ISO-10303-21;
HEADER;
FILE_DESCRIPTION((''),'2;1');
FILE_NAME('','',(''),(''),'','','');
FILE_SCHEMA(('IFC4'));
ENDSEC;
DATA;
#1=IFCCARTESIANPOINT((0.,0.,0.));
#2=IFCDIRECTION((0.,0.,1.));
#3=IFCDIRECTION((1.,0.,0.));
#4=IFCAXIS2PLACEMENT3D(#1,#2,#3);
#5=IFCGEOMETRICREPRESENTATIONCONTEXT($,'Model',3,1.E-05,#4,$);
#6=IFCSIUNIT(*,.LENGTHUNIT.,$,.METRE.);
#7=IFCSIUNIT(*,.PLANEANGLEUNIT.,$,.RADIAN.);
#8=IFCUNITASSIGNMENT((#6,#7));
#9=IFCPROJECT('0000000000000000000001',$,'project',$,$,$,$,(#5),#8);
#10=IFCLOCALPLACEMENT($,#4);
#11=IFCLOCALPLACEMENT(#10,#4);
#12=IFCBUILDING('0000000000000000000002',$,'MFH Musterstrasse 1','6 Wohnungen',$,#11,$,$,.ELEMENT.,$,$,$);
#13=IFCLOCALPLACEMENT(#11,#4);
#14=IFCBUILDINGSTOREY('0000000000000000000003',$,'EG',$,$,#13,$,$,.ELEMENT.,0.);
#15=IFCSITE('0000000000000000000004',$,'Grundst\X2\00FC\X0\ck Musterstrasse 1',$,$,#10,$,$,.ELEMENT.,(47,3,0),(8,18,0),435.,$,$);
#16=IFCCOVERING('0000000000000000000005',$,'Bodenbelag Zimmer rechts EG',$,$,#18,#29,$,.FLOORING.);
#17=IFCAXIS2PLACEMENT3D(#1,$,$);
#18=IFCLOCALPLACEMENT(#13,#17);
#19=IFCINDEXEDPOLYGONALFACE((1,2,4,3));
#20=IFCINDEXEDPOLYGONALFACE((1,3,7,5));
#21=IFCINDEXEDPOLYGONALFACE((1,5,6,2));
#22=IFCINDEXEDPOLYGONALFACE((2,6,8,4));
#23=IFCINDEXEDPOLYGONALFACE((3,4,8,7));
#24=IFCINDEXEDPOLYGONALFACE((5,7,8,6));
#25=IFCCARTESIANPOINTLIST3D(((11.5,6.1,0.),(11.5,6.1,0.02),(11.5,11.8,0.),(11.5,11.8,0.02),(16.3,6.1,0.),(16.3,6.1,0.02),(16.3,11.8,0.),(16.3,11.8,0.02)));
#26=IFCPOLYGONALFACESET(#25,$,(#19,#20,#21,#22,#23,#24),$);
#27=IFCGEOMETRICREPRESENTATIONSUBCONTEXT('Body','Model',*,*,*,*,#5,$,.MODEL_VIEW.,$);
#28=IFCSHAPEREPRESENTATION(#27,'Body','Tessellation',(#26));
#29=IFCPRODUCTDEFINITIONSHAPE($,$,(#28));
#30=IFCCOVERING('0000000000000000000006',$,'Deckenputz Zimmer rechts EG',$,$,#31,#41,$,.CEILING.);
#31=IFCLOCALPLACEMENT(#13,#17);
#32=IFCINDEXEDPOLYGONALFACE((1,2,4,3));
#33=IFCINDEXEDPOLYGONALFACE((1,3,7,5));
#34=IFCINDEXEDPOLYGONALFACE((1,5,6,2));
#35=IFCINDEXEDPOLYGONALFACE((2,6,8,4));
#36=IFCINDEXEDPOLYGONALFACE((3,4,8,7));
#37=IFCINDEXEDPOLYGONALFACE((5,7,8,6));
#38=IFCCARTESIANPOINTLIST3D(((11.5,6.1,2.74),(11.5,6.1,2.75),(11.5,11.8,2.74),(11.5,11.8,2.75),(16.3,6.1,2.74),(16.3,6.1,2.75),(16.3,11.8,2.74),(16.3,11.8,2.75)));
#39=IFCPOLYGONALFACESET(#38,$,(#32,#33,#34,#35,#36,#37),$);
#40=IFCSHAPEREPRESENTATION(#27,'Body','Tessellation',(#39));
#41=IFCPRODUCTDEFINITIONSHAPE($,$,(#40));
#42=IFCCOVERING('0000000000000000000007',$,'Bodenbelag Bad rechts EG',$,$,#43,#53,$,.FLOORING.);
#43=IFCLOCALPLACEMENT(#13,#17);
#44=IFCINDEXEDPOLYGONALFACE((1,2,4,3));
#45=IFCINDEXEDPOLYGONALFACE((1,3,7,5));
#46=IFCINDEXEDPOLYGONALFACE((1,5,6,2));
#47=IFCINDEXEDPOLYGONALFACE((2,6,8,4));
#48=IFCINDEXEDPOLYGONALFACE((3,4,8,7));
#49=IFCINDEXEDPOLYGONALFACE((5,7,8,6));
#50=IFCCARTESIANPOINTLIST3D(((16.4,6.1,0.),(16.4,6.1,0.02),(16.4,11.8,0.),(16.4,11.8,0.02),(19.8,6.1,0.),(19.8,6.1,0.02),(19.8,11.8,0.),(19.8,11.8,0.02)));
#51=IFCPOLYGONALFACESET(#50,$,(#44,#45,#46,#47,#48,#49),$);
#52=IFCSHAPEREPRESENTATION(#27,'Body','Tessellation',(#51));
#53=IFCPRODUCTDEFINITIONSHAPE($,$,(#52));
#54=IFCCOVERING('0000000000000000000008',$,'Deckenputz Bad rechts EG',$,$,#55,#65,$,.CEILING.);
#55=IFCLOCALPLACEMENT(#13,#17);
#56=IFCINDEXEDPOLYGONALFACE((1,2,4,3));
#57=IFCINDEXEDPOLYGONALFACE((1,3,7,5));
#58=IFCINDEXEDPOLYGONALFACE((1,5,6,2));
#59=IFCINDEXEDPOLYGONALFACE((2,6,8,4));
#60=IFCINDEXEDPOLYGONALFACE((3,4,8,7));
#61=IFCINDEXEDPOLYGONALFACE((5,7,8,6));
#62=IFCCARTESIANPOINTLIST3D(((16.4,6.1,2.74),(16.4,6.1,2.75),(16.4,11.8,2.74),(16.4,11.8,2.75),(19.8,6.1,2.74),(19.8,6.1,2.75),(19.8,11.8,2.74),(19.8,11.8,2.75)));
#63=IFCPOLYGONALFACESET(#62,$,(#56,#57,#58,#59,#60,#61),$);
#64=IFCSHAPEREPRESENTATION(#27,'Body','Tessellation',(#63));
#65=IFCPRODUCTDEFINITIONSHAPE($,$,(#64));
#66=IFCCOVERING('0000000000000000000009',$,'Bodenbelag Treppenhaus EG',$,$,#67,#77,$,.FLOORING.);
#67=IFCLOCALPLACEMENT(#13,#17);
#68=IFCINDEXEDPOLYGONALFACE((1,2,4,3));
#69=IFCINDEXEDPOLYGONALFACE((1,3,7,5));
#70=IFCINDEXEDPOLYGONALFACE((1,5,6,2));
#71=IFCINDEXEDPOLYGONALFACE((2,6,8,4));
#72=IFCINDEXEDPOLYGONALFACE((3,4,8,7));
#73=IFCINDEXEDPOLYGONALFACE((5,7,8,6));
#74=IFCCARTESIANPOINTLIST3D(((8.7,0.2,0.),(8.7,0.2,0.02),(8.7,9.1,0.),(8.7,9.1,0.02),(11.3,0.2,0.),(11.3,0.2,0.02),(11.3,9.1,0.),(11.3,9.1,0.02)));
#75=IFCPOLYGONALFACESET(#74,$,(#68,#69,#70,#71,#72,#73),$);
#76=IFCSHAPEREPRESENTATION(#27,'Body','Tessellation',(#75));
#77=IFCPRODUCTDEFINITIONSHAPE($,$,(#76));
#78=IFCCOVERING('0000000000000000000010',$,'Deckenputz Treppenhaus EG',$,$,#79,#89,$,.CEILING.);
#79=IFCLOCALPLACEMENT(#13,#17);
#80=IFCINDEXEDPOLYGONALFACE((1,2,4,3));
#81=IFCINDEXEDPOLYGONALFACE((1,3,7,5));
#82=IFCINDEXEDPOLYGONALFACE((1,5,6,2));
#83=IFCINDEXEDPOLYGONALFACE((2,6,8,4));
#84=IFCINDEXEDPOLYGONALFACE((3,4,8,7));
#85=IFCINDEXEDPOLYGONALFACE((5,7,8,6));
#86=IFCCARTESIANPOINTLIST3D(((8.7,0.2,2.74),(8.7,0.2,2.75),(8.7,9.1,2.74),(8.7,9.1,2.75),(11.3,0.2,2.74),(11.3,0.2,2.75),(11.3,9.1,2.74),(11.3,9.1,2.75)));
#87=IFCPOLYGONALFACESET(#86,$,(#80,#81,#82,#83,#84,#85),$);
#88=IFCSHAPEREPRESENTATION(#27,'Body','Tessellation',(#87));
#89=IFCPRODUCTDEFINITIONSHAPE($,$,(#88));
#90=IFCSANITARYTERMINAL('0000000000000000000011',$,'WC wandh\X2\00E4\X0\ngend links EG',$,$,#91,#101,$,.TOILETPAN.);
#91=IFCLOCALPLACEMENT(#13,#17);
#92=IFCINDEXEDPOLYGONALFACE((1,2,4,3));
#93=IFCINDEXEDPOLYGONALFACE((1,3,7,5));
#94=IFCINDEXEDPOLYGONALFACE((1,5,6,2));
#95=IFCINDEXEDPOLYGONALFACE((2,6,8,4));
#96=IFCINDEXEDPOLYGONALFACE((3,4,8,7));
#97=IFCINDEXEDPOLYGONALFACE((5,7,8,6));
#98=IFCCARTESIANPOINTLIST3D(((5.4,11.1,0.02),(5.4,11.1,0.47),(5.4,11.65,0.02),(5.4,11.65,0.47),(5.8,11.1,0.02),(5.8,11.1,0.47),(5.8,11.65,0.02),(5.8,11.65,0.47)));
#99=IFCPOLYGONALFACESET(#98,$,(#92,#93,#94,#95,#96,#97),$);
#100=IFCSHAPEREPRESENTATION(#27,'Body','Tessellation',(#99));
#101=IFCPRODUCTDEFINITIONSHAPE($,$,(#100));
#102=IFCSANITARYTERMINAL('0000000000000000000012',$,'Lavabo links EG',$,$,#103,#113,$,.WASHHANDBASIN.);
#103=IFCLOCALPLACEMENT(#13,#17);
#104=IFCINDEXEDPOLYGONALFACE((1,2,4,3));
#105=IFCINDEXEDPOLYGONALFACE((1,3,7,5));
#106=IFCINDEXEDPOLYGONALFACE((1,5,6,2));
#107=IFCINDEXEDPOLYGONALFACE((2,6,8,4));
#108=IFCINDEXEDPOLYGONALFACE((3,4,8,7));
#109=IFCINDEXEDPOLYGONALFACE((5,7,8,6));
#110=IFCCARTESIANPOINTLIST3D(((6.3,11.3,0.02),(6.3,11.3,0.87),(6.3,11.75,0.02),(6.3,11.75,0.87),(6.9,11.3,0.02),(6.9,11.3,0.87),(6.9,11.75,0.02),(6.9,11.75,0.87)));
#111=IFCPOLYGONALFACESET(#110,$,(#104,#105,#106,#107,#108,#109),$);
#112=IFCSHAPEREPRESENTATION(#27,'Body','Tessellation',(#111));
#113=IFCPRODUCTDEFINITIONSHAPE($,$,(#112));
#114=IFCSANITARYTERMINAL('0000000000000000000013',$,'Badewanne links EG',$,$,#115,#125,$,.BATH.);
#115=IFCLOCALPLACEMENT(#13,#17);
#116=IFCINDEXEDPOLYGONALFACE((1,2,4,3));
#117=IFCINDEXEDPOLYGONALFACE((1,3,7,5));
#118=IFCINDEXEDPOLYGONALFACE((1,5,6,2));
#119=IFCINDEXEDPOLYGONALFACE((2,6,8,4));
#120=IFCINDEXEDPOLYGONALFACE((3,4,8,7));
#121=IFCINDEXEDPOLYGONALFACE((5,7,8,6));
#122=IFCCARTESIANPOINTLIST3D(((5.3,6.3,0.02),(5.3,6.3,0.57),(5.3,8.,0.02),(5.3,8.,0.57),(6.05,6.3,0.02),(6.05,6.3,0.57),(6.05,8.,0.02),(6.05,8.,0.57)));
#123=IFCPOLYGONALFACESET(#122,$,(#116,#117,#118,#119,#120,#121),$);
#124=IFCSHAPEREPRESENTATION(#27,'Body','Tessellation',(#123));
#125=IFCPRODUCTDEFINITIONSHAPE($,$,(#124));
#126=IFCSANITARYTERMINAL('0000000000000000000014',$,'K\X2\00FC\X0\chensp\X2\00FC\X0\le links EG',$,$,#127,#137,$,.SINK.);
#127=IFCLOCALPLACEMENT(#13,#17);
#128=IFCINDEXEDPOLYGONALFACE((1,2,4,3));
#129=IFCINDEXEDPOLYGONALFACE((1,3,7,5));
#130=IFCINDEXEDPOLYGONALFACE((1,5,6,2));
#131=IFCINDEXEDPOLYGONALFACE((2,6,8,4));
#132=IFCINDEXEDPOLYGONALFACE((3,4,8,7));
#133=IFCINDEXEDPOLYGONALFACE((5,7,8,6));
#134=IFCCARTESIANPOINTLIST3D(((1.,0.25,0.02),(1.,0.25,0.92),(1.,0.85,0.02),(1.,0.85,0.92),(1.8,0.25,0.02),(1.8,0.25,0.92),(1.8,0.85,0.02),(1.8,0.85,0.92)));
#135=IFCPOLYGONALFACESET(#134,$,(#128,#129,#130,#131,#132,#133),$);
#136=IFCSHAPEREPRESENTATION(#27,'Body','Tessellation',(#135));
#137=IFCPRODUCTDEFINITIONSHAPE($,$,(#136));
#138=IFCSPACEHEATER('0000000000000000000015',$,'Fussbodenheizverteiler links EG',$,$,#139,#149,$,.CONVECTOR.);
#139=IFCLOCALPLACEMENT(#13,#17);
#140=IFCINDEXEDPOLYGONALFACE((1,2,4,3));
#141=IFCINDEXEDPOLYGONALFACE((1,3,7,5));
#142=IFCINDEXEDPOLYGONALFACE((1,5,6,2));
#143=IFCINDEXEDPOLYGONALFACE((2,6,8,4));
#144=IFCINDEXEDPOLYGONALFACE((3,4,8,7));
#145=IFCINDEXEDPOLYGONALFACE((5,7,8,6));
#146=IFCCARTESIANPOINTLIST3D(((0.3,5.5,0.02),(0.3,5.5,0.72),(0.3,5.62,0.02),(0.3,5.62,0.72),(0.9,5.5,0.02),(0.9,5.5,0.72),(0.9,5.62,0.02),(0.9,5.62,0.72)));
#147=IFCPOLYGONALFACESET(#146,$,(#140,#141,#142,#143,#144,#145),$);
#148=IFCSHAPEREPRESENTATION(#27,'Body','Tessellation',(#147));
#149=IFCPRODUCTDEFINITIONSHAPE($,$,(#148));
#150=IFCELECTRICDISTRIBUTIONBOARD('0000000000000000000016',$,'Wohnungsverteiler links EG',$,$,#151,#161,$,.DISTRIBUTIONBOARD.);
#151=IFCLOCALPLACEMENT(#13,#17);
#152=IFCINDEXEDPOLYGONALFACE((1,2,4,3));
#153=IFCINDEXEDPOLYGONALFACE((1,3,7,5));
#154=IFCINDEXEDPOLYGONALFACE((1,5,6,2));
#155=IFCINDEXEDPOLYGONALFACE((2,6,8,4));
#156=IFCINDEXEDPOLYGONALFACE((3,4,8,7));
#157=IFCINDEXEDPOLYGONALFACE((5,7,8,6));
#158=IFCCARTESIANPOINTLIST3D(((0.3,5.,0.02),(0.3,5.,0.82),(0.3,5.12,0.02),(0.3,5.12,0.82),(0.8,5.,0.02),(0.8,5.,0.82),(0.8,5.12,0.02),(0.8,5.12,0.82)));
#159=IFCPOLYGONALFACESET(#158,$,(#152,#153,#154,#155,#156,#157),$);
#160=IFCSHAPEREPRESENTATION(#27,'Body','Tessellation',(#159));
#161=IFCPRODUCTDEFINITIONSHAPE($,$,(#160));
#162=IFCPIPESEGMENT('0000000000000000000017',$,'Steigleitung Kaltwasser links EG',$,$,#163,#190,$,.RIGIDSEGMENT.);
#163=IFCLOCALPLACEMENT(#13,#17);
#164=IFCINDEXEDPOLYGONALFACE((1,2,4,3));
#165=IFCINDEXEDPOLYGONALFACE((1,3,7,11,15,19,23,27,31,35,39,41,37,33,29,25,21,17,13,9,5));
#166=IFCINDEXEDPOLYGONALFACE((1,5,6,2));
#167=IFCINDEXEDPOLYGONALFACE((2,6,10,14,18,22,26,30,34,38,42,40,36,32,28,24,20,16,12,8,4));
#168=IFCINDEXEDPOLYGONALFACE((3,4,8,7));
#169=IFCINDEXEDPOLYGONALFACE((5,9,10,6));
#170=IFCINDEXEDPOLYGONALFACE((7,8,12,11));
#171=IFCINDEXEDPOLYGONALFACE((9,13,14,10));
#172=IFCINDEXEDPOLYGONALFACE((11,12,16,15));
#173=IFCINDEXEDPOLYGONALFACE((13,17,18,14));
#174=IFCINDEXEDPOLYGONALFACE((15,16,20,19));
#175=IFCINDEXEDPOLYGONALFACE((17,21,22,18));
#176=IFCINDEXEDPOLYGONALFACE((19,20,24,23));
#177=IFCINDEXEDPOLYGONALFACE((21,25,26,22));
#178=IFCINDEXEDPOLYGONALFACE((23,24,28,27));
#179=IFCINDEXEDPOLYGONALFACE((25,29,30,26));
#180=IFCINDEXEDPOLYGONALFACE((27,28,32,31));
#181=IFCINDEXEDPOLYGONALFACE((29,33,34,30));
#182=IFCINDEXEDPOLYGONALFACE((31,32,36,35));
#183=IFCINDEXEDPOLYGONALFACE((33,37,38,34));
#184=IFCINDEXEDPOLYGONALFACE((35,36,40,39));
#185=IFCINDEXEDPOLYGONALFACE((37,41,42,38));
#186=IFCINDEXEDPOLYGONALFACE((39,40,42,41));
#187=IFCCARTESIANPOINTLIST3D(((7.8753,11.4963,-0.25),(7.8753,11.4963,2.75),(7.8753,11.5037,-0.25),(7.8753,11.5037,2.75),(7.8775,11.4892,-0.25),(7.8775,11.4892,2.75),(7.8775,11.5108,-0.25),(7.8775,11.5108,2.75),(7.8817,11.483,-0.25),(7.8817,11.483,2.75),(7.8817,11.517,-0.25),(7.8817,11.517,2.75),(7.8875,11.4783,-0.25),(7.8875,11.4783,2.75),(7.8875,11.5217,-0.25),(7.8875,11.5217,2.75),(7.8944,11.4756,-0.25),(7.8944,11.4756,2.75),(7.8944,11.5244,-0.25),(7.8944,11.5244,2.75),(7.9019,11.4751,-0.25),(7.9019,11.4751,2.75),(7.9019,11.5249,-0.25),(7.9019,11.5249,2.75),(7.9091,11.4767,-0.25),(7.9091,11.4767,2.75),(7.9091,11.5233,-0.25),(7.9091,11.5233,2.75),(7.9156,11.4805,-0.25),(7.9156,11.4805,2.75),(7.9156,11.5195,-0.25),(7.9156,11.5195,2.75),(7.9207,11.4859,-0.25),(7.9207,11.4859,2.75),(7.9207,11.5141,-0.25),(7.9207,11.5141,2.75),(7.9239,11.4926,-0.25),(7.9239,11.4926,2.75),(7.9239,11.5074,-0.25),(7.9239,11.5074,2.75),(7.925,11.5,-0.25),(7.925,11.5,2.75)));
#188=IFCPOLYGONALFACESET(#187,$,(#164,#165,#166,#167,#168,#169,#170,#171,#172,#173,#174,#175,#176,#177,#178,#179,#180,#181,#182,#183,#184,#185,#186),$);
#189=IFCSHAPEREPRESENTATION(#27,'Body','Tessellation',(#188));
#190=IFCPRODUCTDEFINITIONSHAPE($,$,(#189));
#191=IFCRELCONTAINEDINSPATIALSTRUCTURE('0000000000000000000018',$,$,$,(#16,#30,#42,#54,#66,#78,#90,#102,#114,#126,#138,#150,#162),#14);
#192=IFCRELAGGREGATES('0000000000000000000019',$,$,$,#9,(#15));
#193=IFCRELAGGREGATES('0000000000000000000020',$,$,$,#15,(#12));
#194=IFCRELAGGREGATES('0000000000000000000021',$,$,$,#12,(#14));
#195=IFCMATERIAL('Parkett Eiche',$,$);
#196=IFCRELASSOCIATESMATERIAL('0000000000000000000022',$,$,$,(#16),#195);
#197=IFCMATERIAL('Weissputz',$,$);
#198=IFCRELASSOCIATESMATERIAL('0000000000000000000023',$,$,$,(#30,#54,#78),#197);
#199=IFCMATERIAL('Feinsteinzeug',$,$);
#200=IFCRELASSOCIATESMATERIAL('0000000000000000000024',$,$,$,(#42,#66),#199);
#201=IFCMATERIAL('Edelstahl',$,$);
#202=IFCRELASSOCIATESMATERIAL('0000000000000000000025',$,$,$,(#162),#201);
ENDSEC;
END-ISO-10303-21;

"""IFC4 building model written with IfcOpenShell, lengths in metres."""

from ifc_helpers import new_model, si_unit, frame, frame_2d, origin_with_axes, origin_2d_with_axis, place, context, subcontext, project, spatial, rectangle, circle, extrude, material, element, save


model = new_model("IFC4")

# Units and contexts
model_context = context("Model", 3, precision=1e-05, world=origin_with_axes())
body_context = subcontext(model_context, "Body", "Model", "MODEL_VIEW")
ifc_project = project(units=[si_unit("LENGTHUNIT", "METRE"), si_unit("PLANEANGLEUNIT", "RADIAN")], contexts=[model_context])

# Site, building, storey
site_placement = place(None, origin_with_axes())
site = spatial("IfcSite", under=ifc_project, at=site_placement, Name="Grundstück Musterstrasse 1", CompositionType="ELEMENT", RefLatitude=(47, 3, 0), RefLongitude=(8, 18, 0), RefElevation=435.0)
building_placement = place(site_placement, origin_with_axes())
building = spatial("IfcBuilding", under=site, at=building_placement, Name="MFH Musterstrasse 1", Description="6 Wohnungen", CompositionType="ELEMENT")
storey_placement = place(building_placement, origin_with_axes())
storey = spatial("IfcBuildingStorey", under=building, at=storey_placement, Name="EG", CompositionType="ELEMENT", Elevation=0.0)

# Coverings
ifc_material_1 = material(Name="Parkett Eiche")
covering_1_placement = place(storey_placement, origin_with_axes())
element("IfcCovering", 1, at=covering_1_placement, inside=storey, material=ifc_material_1, Name="Bodenbelag Zimmer rechts EG", PredefinedType="FLOORING", context=body_context, shape_type="SweptSolid", body=[
    extrude(rectangle(XDim=4.8, YDim=5.7, at=frame_2d((2.4, 2.85), x_axis=(1.0, 0.0))), frame((11.5, 6.1, 0.0), z_axis=(0.0, 0.0, 1.0), x_axis=(1.0, 0.0, 0.0)), (0.0, 0.0, 1.0), 0.02),
])
ifc_material_2 = material(Name="Weissputz")
covering_2_placement = place(storey_placement, origin_with_axes())
element("IfcCovering", 2, at=covering_2_placement, inside=storey, material=ifc_material_2, Name="Deckenputz Zimmer rechts EG", PredefinedType="CEILING", context=body_context, shape_type="SweptSolid", body=[
    extrude(rectangle(XDim=4.8, YDim=5.7, at=frame_2d((2.4, 2.85), x_axis=(1.0, 0.0))), frame((11.5, 6.1, 2.74), z_axis=(0.0, 0.0, 1.0), x_axis=(1.0, 0.0, 0.0)), (0.0, 0.0, 1.0), 0.01),
])
ifc_material_3 = material(Name="Feinsteinzeug")
covering_3_placement = place(storey_placement, origin_with_axes())
element("IfcCovering", 3, at=covering_3_placement, inside=storey, material=ifc_material_3, Name="Bodenbelag Bad rechts EG", PredefinedType="FLOORING", context=body_context, shape_type="SweptSolid", body=[
    extrude(rectangle(XDim=3.4, YDim=5.7, at=frame_2d((1.7, 2.85), x_axis=(1.0, 0.0))), frame((16.4, 6.1, 0.0), z_axis=(0.0, 0.0, 1.0), x_axis=(1.0, 0.0, 0.0)), (0.0, 0.0, 1.0), 0.02),
])
covering_4_placement = place(storey_placement, origin_with_axes())
element("IfcCovering", 4, at=covering_4_placement, inside=storey, material=ifc_material_2, Name="Deckenputz Bad rechts EG", PredefinedType="CEILING", context=body_context, shape_type="SweptSolid", body=[
    extrude(rectangle(XDim=3.4, YDim=5.7, at=frame_2d((1.7, 2.85), x_axis=(1.0, 0.0))), frame((16.4, 6.1, 2.74), z_axis=(0.0, 0.0, 1.0), x_axis=(1.0, 0.0, 0.0)), (0.0, 0.0, 1.0), 0.01),
])
covering_5_placement = place(storey_placement, origin_with_axes())
element("IfcCovering", 5, at=covering_5_placement, inside=storey, material=ifc_material_3, Name="Bodenbelag Treppenhaus EG", PredefinedType="FLOORING", context=body_context, shape_type="SweptSolid", body=[
    extrude(rectangle(XDim=2.6, YDim=8.9, at=frame_2d((1.3, 4.45), x_axis=(1.0, 0.0))), frame((8.7, 0.2, 0.0), z_axis=(0.0, 0.0, 1.0), x_axis=(1.0, 0.0, 0.0)), (0.0, 0.0, 1.0), 0.02),
])
covering_6_placement = place(storey_placement, origin_with_axes())
element("IfcCovering", 6, at=covering_6_placement, inside=storey, material=ifc_material_2, Name="Deckenputz Treppenhaus EG", PredefinedType="CEILING", context=body_context, shape_type="SweptSolid", body=[
    extrude(rectangle(XDim=2.6, YDim=8.9, at=frame_2d((1.3, 4.45), x_axis=(1.0, 0.0))), frame((8.7, 0.2, 2.74), z_axis=(0.0, 0.0, 1.0), x_axis=(1.0, 0.0, 0.0)), (0.0, 0.0, 1.0), 0.01),
])

# Sanitary terminals
sanitary_terminal_1_placement = place(storey_placement, origin_with_axes())
element("IfcSanitaryTerminal", 7, at=sanitary_terminal_1_placement, inside=storey, Name="WC wandhängend links EG", PredefinedType="TOILETPAN", context=body_context, shape_type="SweptSolid", body=[
    extrude(rectangle(XDim=0.4, YDim=0.55, at=frame_2d((0.2, 0.275), x_axis=(1.0, 0.0))), frame((5.4, 11.1, 0.02), z_axis=(0.0, 0.0, 1.0), x_axis=(1.0, 0.0, 0.0)), (0.0, 0.0, 1.0), 0.45),
])
sanitary_terminal_2_placement = place(storey_placement, origin_with_axes())
element("IfcSanitaryTerminal", 8, at=sanitary_terminal_2_placement, inside=storey, Name="Lavabo links EG", PredefinedType="WASHHANDBASIN", context=body_context, shape_type="SweptSolid", body=[
    extrude(rectangle(XDim=0.6, YDim=0.45, at=frame_2d((0.3, 0.225), x_axis=(1.0, 0.0))), frame((6.3, 11.3, 0.02), z_axis=(0.0, 0.0, 1.0), x_axis=(1.0, 0.0, 0.0)), (0.0, 0.0, 1.0), 0.85),
])
sanitary_terminal_3_placement = place(storey_placement, origin_with_axes())
element("IfcSanitaryTerminal", 9, at=sanitary_terminal_3_placement, inside=storey, Name="Badewanne links EG", PredefinedType="BATH", context=body_context, shape_type="SweptSolid", body=[
    extrude(rectangle(XDim=0.75, YDim=1.7, at=frame_2d((0.375, 0.85), x_axis=(1.0, 0.0))), frame((5.3, 6.3, 0.02), z_axis=(0.0, 0.0, 1.0), x_axis=(1.0, 0.0, 0.0)), (0.0, 0.0, 1.0), 0.55),
])
sanitary_terminal_4_placement = place(storey_placement, origin_with_axes())
element("IfcSanitaryTerminal", 10, at=sanitary_terminal_4_placement, inside=storey, Name="Küchenspüle links EG", PredefinedType="SINK", context=body_context, shape_type="SweptSolid", body=[
    extrude(rectangle(XDim=0.8, YDim=0.6, at=frame_2d((0.4, 0.3), x_axis=(1.0, 0.0))), frame((1.0, 0.25, 0.02), z_axis=(0.0, 0.0, 1.0), x_axis=(1.0, 0.0, 0.0)), (0.0, 0.0, 1.0), 0.9),
])

# Space heater
space_heater_1_placement = place(storey_placement, origin_with_axes())
element("IfcSpaceHeater", 11, at=space_heater_1_placement, inside=storey, Name="Fussbodenheizverteiler links EG", PredefinedType="CONVECTOR", context=body_context, shape_type="SweptSolid", body=[
    extrude(rectangle(XDim=0.6, YDim=0.12, at=frame_2d((0.3, 0.06), x_axis=(1.0, 0.0))), frame((0.3, 5.5, 0.02), z_axis=(0.0, 0.0, 1.0), x_axis=(1.0, 0.0, 0.0)), (0.0, 0.0, 1.0), 0.7),
])

# Electric distribution board
electric_distribution_board_1_placement = place(storey_placement, origin_with_axes())
element("IfcElectricDistributionBoard", 12, at=electric_distribution_board_1_placement, inside=storey, Name="Wohnungsverteiler links EG", PredefinedType="DISTRIBUTIONBOARD", context=body_context, shape_type="SweptSolid", body=[
    extrude(rectangle(XDim=0.5, YDim=0.12, at=frame_2d((0.25, 0.06), x_axis=(1.0, 0.0))), frame((0.3, 5.0, 0.02), z_axis=(0.0, 0.0, 1.0), x_axis=(1.0, 0.0, 0.0)), (0.0, 0.0, 1.0), 0.8),
])

# Pipe segment
ifc_material_4 = material(Name="Edelstahl")
pipe_segment_1_placement = place(storey_placement, origin_with_axes())
element("IfcPipeSegment", 13, at=pipe_segment_1_placement, inside=storey, material=ifc_material_4, Name="Steigleitung Kaltwasser links EG", PredefinedType="RIGIDSEGMENT", context=body_context, shape_type="SweptSolid", body=[
    extrude(circle(Radius=0.025, at=origin_2d_with_axis()), frame((7.9, 11.5, -0.25), z_axis=(0.0, 0.0, 1.0), x_axis=(1.0, 0.0, 0.0)), (0.0, 0.0, 1.0), 3.0),
])

save(model, "model.ifc")
